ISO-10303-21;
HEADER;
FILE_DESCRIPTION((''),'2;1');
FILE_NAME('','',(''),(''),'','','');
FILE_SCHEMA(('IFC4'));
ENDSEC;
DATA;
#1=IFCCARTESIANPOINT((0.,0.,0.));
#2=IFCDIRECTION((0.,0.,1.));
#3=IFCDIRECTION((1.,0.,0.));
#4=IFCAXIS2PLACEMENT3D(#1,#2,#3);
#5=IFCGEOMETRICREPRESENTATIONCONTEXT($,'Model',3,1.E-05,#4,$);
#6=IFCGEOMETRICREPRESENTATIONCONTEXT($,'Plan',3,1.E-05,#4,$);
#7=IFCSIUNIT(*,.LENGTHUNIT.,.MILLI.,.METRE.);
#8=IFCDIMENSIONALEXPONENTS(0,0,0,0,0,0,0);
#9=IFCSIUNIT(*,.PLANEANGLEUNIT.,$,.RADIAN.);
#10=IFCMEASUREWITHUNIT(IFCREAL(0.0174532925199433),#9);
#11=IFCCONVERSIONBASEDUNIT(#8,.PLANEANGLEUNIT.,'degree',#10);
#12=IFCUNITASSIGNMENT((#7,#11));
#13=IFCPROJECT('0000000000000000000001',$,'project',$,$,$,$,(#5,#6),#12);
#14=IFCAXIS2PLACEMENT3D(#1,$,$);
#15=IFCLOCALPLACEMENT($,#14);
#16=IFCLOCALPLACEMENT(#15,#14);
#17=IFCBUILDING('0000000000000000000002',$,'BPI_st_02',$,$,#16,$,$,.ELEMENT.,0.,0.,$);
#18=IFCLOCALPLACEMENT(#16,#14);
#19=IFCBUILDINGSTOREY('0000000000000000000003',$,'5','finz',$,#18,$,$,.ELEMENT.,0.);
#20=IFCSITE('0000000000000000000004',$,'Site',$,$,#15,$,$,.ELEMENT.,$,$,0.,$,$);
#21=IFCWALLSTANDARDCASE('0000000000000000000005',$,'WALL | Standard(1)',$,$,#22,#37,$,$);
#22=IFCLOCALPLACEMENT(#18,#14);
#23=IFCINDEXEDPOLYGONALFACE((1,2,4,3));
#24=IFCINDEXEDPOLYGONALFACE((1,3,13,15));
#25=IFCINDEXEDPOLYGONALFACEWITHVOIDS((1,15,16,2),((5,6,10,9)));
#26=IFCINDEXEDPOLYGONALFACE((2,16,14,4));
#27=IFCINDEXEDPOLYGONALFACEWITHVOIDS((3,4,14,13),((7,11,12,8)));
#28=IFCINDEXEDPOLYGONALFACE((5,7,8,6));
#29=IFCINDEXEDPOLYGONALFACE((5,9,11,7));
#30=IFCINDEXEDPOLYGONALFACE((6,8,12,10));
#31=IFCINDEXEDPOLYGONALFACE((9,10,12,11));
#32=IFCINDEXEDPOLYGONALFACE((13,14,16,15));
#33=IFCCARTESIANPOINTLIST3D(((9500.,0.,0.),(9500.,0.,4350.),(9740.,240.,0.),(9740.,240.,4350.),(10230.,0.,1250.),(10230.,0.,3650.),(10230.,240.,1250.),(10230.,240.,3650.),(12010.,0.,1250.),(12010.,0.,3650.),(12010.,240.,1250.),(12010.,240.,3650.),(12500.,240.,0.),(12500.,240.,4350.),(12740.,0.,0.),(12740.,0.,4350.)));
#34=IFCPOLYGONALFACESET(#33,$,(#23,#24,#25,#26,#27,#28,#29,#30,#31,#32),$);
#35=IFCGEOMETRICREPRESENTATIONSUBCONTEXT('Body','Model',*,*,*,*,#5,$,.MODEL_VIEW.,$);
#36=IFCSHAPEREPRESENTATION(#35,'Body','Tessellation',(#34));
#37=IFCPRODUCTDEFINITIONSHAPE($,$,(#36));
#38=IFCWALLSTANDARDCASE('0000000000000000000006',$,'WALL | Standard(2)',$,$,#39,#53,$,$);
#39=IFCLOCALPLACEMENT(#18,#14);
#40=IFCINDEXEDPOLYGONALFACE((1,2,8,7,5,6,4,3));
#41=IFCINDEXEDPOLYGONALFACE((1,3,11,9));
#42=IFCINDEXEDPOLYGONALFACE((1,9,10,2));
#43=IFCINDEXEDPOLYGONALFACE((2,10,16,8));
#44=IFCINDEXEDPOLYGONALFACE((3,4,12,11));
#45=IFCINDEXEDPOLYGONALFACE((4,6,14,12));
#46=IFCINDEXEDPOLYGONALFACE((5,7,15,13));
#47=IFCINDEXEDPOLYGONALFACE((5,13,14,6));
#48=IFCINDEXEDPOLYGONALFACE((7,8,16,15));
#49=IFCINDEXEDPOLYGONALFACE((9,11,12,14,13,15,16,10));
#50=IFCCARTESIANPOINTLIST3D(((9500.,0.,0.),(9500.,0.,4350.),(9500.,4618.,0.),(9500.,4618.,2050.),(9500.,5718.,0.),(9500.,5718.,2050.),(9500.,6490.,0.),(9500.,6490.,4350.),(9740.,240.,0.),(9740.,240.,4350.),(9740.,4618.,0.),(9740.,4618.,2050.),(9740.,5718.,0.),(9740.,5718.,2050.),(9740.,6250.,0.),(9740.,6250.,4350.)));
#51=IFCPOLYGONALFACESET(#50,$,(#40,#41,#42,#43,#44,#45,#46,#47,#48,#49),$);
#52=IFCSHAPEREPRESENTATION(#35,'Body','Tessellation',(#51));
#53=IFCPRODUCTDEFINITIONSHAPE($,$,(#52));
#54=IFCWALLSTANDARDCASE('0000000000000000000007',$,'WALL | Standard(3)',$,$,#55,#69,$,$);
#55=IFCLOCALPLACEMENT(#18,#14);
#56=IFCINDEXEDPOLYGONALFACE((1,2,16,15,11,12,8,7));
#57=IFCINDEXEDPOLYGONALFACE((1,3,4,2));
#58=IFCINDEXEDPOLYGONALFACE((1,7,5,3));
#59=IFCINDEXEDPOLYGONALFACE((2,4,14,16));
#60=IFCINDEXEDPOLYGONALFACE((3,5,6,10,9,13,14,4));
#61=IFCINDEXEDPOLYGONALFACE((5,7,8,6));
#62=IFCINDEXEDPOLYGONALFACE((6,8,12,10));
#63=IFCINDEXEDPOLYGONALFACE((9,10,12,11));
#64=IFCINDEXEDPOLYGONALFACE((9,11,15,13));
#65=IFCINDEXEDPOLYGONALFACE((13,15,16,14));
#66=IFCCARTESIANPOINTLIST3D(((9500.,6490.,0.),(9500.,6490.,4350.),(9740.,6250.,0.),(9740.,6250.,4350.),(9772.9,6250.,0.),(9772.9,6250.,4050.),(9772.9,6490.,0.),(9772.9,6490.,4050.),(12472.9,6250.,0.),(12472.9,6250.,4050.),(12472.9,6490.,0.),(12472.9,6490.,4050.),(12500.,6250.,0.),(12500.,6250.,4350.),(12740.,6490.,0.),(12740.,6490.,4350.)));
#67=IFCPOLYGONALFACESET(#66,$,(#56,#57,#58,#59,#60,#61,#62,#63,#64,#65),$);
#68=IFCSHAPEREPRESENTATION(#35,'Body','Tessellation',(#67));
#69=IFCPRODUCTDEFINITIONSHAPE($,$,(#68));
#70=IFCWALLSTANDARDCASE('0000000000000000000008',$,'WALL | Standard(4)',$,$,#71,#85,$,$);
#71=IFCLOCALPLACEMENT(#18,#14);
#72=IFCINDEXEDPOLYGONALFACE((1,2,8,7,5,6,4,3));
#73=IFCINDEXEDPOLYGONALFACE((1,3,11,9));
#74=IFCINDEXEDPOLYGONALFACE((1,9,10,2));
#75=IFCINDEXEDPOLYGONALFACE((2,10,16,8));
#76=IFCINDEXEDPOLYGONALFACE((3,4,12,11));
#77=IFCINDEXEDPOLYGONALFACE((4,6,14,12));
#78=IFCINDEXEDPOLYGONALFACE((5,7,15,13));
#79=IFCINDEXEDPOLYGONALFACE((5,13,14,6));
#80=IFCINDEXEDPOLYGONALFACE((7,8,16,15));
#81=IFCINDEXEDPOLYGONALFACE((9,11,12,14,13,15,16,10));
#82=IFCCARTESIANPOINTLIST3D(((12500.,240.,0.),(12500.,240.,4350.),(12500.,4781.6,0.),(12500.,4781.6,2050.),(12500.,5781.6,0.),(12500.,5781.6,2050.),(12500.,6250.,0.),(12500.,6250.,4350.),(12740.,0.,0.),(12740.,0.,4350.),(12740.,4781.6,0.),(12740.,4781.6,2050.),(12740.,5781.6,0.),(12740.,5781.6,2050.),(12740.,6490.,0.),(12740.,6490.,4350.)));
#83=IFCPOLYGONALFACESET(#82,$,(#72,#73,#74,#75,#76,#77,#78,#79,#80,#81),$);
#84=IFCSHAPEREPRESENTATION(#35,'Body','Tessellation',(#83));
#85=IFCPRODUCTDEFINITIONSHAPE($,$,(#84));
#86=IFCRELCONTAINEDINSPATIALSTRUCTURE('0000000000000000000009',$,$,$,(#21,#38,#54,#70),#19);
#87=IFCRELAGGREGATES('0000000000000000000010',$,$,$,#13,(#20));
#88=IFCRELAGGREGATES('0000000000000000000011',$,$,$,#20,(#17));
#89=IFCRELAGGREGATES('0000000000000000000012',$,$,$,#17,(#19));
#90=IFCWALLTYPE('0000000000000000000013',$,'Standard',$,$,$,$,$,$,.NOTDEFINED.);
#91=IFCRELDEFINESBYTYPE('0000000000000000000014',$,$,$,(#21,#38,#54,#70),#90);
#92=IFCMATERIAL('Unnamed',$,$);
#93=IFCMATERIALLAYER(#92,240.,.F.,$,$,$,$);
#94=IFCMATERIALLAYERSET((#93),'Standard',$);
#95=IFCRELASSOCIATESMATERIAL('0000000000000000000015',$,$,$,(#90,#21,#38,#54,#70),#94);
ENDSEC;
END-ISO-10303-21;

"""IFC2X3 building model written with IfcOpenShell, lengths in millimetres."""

from ifc_helpers import new_model, entity, si_unit, converted_unit, frame, origin, origin_with_axes, origin_2d_with_axis, place, context, subcontext, project, spatial, polyline, segment, composite_curve, rectangle, outline, extrude, material, layer, layer_set, layer_usage, type_object, element, save


model = new_model("IFC2X3")

# Units and contexts
model_context = context("Model", 3, precision=1e-05, world=origin_with_axes())
plan_context = context("Plan", 3, precision=1e-05, world=origin_with_axes())
body_context = subcontext(model_context, "Body", "Model", "MODEL_VIEW")
ifc_project = project(units=[si_unit("LENGTHUNIT", "METRE", prefix="MILLI"), converted_unit("PLANEANGLEUNIT", "degree", entity("IfcReal", 0.0174532925199433), si_unit("PLANEANGLEUNIT", "RADIAN"), dimensions=[0, 0, 0, 0, 0, 0, 0])], contexts=[model_context, plan_context])

# Site, building, storey
site_placement = place(None, origin())
site = spatial("IfcSite", under=ifc_project, at=site_placement, Name="Site", CompositionType="ELEMENT", RefElevation=0.0)
building_placement = place(site_placement, origin())
building = spatial("IfcBuilding", under=site, at=building_placement, Name="BPI_st_02", CompositionType="ELEMENT", ElevationOfRefHeight=0.0, ElevationOfTerrain=0.0)
storey_placement = place(building_placement, origin())
storey = spatial("IfcBuildingStorey", under=building, at=storey_placement, Name="5", Description="finz", CompositionType="ELEMENT", Elevation=0.0)

# Shared definitions
ifc_material = material(Name="Unnamed")

# Walls, openings
ifc_layer_1 = layer(ifc_material, 240.0, ventilated=False)
ifc_layer_set_1 = layer_set([ifc_layer_1], Name="Standard")
ifc_layer_usage_1 = layer_usage(ifc_layer_set_1, "AXIS2", "POSITIVE", -120.0)
wall_type = type_object("IfcWallType", Name="Standard", PredefinedType="NOTDEFINED", material=ifc_layer_set_1)
wall_1_placement = place(storey_placement, frame((12620.0, 120.0, 0.0), z_axis=(0.0, 0.0, 1.0), x_axis=(-1.0, 0.0, 0.0)))
wall_1 = element("IfcWallStandardCase", 1, at=wall_1_placement, inside=storey, type_object=wall_type, material=ifc_layer_usage_1, Name="WALL | Standard(1)", context=body_context, shape_type="SweptSolid", body=[
    extrude(outline(composite_curve([segment(polyline([(-120.0, 120.0), (120.0, -120.0)]), True, "CONTINUOUS"), segment(polyline([(120.0, -120.0), (2880.0, -120.0)]), True, "CONTINUOUS"), segment(polyline([(2880.0, -120.0), (3120.0, 120.0)]), True, "CONTINUOUS"), segment(polyline([(3120.0, 120.0), (-120.0, 120.0)]), True, "CONTINUOUS")], self_intersect=False)), origin(), (0.0, 0.0, 1.0), 4350.0),
])
opening_1_placement = place(wall_1_placement, frame((610.0, 0.0, 1250.0)))
element("IfcOpeningElement", 2, at=opening_1_placement, cuts=wall_1, context=body_context, shape_type="SweptSolid", body=[
    extrude(rectangle(XDim=1780.0, YDim=2400.0, at=origin_2d_with_axis()), frame((890.0, 120.0, 1200.0), z_axis=(0.0, -1.0, 0.0), x_axis=(1.0, 0.0, 0.0)), (0.0, 0.0, 1.0), 240.0),
])
ifc_layer_usage_2 = layer_usage(ifc_layer_set_1, "AXIS2", "POSITIVE", -120.0)
wall_2_placement = place(storey_placement, frame((9620.0, 6370.0, 0.0), z_axis=(0.0, 0.0, 1.0), x_axis=(0.0, -1.0, 0.0)))
wall_2 = element("IfcWallStandardCase", 3, at=wall_2_placement, inside=storey, type_object=wall_type, material=ifc_layer_usage_2, Name="WALL | Standard(2)", context=body_context, shape_type="SweptSolid", body=[
    extrude(outline(composite_curve([segment(polyline([(120.0, 120.0), (-120.0, -120.0)]), True, "CONTINUOUS"), segment(polyline([(-120.0, -120.0), (6370.0, -120.0)]), True, "CONTINUOUS"), segment(polyline([(6370.0, -120.0), (6130.0, 120.0)]), True, "CONTINUOUS"), segment(polyline([(6130.0, 120.0), (120.0, 120.0)]), True, "CONTINUOUS")], self_intersect=False)), origin(), (0.0, 0.0, 1.0), 4350.0),
])
opening_2_placement = place(wall_2_placement, frame((652.0, 0.0, 0.0)))
element("IfcOpeningElement", 4, at=opening_2_placement, cuts=wall_2, context=body_context, shape_type="SweptSolid", body=[
    extrude(rectangle(XDim=1100.0, YDim=2050.0, at=origin_2d_with_axis()), frame((550.0, 120.0, 1025.0), z_axis=(0.0, -1.0, 0.0), x_axis=(1.0, 0.0, 0.0)), (0.0, 0.0, 1.0), 240.0),
])
ifc_layer_usage_3 = layer_usage(ifc_layer_set_1, "AXIS2", "POSITIVE", -120.0)
wall_3_placement = place(storey_placement, frame((9620.0, 6370.0, 0.0)))
wall_3 = element("IfcWallStandardCase", 5, at=wall_3_placement, inside=storey, type_object=wall_type, material=ifc_layer_usage_3, Name="WALL | Standard(3)", context=body_context, shape_type="SweptSolid", body=[
    extrude(outline(composite_curve([segment(polyline([(-120.0, 120.0), (120.0, -120.0)]), True, "CONTINUOUS"), segment(polyline([(120.0, -120.0), (2880.0, -120.0)]), True, "CONTINUOUS"), segment(polyline([(2880.0, -120.0), (3120.0, 120.0)]), True, "CONTINUOUS"), segment(polyline([(3120.0, 120.0), (-120.0, 120.0)]), True, "CONTINUOUS")], self_intersect=False)), origin(), (0.0, 0.0, 1.0), 4350.0),
])
opening_3_placement = place(wall_3_placement, frame((152.9, 0.0, 0.0)))
element("IfcOpeningElement", 6, at=opening_3_placement, cuts=wall_3, context=body_context, shape_type="SweptSolid", body=[
    extrude(rectangle(XDim=2700.0, YDim=4050.0, at=origin_2d_with_axis()), frame((1350.0, 120.0, 2025.0), z_axis=(0.0, -1.0, 0.0), x_axis=(1.0, 0.0, 0.0)), (0.0, 0.0, 1.0), 240.0),
])
ifc_layer_usage_4 = layer_usage(ifc_layer_set_1, "AXIS2", "POSITIVE", -120.0)
wall_4_placement = place(storey_placement, frame((12620.0, 6370.0, 0.0), z_axis=(0.0, 0.0, 1.0), x_axis=(0.0, -1.0, 0.0)))
wall_4 = element("IfcWallStandardCase", 7, at=wall_4_placement, inside=storey, type_object=wall_type, material=ifc_layer_usage_4, Name="WALL | Standard(4)", context=body_context, shape_type="SweptSolid", body=[
    extrude(outline(composite_curve([segment(polyline([(-120.0, 120.0), (120.0, -120.0)]), True, "CONTINUOUS"), segment(polyline([(120.0, -120.0), (6130.0, -120.0)]), True, "CONTINUOUS"), segment(polyline([(6130.0, -120.0), (6370.0, 120.0)]), True, "CONTINUOUS"), segment(polyline([(6370.0, 120.0), (-120.0, 120.0)]), True, "CONTINUOUS")], self_intersect=False)), origin(), (0.0, 0.0, 1.0), 4350.0),
])
opening_4_placement = place(wall_4_placement, frame((588.4, 0.0, 0.0)))
element("IfcOpeningElement", 8, at=opening_4_placement, cuts=wall_4, context=body_context, shape_type="SweptSolid", body=[
    extrude(rectangle(XDim=1000.0, YDim=2050.0, at=origin_2d_with_axis()), frame((500.0, 120.0, 1025.0), z_axis=(0.0, -1.0, 0.0), x_axis=(1.0, 0.0, 0.0)), (0.0, 0.0, 1.0), 240.0),
])

save(model, "model.ifc")
